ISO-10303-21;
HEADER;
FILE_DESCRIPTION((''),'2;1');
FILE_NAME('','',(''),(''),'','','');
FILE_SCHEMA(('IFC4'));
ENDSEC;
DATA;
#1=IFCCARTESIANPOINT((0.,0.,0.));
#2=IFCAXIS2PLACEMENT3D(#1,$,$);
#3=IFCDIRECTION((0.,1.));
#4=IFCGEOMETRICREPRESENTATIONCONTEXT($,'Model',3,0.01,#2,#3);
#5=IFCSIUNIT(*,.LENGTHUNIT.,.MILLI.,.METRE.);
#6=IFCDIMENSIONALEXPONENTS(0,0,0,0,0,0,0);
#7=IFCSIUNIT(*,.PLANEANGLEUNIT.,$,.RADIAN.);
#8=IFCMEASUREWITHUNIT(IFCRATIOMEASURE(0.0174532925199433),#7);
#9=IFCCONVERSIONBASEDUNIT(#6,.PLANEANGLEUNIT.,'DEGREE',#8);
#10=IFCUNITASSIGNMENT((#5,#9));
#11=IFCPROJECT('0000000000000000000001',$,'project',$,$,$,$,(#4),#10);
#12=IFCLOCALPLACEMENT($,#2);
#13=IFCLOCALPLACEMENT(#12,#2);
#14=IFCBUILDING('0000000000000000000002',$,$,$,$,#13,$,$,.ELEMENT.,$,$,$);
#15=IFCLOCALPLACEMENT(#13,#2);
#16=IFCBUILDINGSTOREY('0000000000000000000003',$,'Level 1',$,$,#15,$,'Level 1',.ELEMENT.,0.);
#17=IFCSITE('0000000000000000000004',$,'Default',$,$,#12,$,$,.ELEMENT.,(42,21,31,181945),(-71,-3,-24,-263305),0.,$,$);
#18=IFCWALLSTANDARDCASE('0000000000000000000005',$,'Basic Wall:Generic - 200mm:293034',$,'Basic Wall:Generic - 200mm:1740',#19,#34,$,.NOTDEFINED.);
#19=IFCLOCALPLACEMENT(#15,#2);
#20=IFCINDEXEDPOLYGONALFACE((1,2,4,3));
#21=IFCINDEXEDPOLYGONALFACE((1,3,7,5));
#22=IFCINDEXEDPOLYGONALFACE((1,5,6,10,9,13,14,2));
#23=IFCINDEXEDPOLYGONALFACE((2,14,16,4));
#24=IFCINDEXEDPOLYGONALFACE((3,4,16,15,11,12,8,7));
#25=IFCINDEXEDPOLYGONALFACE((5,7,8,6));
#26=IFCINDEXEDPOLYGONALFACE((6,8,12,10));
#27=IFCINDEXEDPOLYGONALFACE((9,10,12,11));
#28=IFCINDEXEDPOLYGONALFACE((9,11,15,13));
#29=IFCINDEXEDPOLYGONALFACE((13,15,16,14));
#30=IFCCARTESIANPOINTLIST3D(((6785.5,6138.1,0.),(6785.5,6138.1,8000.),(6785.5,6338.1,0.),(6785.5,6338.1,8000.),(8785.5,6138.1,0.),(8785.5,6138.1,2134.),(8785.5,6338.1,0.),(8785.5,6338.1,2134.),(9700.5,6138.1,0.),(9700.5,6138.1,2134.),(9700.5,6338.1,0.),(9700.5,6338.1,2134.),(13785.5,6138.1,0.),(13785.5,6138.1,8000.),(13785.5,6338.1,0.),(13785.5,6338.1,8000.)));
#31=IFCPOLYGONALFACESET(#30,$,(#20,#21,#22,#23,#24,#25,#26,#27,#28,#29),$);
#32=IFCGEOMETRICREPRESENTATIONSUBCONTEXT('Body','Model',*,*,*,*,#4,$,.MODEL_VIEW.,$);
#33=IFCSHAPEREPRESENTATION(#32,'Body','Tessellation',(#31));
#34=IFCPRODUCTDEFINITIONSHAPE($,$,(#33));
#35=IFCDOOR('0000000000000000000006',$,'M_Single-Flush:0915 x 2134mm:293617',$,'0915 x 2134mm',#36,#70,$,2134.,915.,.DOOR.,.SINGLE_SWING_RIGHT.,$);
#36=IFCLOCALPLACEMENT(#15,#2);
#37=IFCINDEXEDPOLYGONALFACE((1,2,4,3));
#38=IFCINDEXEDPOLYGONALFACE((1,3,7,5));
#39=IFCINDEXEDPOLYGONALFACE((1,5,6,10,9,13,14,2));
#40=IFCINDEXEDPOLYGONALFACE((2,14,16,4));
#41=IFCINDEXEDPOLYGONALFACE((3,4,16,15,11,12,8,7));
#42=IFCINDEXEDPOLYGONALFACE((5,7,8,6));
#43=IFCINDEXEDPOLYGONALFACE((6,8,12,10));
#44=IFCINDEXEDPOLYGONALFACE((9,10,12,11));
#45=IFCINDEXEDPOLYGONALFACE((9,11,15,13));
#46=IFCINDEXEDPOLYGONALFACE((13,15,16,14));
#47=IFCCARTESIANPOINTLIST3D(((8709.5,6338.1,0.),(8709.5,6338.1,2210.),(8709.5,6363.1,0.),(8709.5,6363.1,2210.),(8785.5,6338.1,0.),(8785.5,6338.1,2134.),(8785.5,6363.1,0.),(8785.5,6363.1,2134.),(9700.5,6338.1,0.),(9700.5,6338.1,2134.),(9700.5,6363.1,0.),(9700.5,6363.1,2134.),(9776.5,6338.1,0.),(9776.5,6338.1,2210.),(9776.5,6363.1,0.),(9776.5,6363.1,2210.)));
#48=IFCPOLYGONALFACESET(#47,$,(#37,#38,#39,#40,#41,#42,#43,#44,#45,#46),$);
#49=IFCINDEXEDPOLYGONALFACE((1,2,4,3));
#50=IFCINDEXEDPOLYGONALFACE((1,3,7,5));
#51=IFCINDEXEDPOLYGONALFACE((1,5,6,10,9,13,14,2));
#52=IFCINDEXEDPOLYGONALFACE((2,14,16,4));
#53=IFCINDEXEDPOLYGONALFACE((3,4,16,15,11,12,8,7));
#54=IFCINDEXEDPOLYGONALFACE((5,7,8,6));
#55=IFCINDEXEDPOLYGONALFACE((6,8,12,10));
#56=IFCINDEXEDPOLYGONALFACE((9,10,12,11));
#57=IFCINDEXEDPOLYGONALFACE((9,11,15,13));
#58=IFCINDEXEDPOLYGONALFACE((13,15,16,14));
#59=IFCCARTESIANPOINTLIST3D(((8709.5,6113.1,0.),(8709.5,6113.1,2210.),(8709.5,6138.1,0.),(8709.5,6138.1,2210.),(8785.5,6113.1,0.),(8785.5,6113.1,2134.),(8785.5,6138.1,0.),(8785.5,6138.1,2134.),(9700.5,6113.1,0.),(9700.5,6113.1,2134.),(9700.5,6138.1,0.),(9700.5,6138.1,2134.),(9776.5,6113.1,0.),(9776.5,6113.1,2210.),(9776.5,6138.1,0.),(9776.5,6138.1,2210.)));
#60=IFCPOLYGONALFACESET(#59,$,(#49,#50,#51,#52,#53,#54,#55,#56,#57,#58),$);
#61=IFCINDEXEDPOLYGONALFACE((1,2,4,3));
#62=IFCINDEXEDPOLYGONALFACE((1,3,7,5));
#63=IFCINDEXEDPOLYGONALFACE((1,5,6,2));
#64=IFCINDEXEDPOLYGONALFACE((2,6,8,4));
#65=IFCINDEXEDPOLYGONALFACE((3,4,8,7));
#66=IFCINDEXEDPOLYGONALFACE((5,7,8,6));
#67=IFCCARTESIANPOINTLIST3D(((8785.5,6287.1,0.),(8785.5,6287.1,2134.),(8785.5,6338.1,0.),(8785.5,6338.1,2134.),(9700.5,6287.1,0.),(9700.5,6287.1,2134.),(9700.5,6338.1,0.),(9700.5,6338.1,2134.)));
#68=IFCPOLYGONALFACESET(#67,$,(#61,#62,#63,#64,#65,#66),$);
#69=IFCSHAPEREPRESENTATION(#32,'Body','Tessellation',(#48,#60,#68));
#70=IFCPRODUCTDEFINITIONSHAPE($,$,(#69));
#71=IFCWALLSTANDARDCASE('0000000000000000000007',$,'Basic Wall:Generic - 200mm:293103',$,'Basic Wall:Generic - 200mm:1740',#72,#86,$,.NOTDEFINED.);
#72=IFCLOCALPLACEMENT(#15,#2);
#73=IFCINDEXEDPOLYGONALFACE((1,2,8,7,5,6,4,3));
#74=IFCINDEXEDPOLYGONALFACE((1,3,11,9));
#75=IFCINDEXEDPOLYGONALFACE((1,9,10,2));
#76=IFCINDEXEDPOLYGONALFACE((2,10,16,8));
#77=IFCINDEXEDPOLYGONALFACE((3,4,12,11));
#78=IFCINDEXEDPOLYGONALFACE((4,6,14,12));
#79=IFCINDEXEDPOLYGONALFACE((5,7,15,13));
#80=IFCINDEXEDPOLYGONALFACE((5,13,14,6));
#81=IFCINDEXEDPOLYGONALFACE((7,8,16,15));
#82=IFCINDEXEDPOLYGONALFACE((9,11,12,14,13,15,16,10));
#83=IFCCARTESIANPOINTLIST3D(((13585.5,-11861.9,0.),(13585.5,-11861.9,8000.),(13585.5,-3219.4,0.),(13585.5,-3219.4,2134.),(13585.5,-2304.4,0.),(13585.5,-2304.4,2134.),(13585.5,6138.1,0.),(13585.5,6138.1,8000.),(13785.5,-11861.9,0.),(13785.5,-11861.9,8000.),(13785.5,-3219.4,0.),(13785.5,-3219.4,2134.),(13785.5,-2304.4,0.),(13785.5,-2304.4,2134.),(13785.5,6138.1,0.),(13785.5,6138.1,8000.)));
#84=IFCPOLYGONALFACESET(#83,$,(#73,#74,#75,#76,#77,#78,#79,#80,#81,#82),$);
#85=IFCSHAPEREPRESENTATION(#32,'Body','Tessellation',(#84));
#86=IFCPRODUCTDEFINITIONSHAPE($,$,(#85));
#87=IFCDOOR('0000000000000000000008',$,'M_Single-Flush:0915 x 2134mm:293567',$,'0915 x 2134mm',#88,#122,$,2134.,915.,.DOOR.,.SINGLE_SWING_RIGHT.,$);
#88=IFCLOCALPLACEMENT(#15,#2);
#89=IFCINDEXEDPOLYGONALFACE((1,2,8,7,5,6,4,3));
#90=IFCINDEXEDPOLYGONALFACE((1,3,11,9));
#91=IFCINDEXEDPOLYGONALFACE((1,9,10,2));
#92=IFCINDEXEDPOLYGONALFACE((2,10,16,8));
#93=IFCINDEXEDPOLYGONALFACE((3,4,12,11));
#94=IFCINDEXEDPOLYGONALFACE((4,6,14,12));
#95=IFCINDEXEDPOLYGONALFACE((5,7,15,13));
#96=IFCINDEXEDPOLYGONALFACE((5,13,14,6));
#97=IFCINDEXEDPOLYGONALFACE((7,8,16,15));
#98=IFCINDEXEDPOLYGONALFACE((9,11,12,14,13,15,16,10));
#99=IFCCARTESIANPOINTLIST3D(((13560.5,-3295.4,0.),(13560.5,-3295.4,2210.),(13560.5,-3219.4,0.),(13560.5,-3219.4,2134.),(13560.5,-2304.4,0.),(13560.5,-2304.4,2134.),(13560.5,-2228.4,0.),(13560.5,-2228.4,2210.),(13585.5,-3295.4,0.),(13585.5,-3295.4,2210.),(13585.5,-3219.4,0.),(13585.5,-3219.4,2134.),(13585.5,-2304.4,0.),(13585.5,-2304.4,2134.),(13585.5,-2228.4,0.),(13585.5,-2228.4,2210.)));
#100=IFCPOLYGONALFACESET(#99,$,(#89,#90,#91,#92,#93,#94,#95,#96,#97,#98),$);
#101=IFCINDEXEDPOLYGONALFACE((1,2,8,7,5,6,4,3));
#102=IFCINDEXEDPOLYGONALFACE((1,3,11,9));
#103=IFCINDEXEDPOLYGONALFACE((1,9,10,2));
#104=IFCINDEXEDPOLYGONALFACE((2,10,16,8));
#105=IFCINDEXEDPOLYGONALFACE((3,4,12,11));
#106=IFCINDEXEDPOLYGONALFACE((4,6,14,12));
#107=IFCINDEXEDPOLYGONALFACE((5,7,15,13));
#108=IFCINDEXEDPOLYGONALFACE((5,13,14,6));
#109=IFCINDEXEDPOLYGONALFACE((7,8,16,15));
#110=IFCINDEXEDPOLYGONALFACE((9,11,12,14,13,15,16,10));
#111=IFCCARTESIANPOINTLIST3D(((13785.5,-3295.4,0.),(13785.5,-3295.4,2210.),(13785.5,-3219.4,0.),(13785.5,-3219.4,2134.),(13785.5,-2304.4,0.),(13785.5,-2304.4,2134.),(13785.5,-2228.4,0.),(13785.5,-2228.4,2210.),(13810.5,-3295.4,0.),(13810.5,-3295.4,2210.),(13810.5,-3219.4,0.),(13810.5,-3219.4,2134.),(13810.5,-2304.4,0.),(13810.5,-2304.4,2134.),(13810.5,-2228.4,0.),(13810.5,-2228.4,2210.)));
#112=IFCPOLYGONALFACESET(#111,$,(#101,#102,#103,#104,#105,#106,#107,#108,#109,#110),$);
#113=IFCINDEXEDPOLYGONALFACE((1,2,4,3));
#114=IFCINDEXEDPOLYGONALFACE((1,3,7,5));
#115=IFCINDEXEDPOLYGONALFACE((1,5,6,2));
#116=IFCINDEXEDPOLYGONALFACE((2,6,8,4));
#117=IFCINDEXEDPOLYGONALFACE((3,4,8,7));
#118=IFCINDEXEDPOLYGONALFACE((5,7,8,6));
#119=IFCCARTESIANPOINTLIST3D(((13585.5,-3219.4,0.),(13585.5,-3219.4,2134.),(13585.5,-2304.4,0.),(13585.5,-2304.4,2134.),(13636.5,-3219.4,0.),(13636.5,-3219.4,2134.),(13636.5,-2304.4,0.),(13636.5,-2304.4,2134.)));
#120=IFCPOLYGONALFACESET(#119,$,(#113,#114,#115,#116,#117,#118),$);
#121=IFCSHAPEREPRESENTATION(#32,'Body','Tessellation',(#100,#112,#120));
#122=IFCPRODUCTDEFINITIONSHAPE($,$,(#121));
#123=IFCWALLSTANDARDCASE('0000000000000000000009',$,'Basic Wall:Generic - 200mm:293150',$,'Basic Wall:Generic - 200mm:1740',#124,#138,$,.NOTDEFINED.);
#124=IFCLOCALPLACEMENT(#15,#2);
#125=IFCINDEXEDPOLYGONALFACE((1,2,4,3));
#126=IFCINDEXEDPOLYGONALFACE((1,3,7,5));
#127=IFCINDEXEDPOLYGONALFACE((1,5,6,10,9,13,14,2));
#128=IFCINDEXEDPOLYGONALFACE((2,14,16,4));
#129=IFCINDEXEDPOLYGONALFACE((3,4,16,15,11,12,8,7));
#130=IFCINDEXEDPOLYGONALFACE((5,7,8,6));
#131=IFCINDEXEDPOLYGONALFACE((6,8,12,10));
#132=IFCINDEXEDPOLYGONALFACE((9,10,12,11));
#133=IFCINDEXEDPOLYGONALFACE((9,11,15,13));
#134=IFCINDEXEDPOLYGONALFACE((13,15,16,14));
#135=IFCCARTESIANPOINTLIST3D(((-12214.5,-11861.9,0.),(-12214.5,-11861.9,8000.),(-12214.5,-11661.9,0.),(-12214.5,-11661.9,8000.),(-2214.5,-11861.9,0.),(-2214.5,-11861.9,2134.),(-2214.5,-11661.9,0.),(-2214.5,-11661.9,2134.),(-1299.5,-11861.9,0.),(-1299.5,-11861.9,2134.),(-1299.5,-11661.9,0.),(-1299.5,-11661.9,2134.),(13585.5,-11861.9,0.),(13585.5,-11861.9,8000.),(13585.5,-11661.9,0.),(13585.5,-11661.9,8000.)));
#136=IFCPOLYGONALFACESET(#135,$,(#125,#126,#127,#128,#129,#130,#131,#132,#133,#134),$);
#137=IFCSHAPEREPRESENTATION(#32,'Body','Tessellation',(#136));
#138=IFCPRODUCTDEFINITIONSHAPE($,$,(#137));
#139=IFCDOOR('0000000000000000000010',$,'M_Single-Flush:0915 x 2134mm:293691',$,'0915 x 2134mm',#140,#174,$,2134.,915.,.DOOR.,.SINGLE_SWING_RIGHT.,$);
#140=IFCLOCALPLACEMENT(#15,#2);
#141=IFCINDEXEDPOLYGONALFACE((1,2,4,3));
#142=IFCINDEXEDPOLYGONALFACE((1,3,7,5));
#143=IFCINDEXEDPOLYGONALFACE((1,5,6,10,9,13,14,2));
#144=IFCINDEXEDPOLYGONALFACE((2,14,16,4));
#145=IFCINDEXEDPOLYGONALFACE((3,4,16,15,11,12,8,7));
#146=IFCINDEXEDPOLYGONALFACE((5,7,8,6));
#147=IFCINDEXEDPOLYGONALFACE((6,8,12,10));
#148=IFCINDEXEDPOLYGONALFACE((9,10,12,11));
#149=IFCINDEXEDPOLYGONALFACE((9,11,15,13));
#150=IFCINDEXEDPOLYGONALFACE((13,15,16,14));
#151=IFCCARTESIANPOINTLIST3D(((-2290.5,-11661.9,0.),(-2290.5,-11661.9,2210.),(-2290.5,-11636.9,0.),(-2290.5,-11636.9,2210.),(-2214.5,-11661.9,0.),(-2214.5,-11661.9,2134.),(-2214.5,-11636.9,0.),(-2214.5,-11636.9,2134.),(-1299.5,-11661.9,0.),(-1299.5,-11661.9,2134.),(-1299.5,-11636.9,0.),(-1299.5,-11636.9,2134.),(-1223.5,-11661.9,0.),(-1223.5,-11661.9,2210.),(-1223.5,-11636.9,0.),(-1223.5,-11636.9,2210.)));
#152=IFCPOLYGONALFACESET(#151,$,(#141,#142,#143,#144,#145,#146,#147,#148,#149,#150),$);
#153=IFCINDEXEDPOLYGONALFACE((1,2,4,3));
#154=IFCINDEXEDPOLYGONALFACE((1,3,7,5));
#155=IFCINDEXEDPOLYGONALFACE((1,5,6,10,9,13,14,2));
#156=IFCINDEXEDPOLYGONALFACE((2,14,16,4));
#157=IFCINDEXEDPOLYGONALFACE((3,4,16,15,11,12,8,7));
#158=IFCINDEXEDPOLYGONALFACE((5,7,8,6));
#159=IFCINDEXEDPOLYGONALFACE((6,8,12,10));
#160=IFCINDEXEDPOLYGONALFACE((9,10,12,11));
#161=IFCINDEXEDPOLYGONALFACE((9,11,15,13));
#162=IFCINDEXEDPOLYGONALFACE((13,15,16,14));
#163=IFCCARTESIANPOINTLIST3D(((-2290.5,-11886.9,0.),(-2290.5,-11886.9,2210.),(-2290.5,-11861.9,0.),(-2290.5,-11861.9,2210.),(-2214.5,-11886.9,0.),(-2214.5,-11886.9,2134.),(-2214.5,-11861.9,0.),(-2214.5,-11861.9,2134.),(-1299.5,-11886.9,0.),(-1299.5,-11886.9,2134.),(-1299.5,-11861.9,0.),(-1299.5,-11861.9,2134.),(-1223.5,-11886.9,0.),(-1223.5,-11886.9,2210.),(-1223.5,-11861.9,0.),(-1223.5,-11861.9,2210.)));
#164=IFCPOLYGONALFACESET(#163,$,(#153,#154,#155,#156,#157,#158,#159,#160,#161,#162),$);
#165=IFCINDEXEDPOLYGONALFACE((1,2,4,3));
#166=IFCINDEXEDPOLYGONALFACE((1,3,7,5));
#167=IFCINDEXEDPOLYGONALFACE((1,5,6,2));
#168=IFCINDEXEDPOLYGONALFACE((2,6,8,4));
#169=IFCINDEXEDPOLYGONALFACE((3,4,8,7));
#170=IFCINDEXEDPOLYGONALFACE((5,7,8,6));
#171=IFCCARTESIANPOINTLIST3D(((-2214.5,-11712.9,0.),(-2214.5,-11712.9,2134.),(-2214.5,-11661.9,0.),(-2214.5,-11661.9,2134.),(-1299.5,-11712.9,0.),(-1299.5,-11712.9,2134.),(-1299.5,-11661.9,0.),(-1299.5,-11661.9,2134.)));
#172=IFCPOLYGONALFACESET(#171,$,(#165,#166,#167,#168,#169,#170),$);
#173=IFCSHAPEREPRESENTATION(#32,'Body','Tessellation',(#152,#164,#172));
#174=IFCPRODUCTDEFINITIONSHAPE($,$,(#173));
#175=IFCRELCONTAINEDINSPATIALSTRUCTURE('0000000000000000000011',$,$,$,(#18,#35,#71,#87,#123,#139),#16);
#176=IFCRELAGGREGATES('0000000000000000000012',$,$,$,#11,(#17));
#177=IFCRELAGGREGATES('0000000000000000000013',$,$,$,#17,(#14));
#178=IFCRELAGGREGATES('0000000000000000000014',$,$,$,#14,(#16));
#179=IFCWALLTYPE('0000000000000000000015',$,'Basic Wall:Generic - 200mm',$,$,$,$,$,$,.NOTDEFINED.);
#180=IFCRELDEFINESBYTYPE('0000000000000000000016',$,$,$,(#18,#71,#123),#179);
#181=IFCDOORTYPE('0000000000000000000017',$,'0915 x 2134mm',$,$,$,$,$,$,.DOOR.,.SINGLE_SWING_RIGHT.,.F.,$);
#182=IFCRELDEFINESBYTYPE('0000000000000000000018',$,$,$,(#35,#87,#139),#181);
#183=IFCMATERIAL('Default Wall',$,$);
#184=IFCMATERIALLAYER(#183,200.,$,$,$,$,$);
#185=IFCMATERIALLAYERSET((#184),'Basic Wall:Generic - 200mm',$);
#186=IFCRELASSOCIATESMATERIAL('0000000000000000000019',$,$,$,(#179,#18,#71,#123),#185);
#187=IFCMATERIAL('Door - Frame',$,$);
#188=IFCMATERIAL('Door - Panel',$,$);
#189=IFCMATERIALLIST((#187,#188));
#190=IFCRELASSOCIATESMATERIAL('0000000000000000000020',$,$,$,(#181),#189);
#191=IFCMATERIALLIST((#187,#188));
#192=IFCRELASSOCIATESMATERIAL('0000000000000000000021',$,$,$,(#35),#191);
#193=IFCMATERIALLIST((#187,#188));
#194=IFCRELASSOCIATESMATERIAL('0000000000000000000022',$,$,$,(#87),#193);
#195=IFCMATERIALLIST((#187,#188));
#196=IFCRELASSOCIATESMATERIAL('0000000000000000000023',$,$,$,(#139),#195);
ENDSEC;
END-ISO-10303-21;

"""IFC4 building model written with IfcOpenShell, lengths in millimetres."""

from ifc_helpers import new_model, entity, si_unit, converted_unit, direction, frame, frame_2d, origin, place, context, subcontext, project, spatial, polyline, rectangle, outline, extrude, source, transform, mapped, material, material_list, layer, layer_set, layer_usage, type_object, type_shapes, element, fill, save


model = new_model("IFC4")

# Units and contexts
model_context = context("Model", 3, precision=0.01, world=origin(), true_north=direction((0.0, 1.0)))
body_context = subcontext(model_context, "Body", "Model", "MODEL_VIEW")
ifc_project = project(units=[si_unit("LENGTHUNIT", "METRE", prefix="MILLI"), converted_unit("PLANEANGLEUNIT", "DEGREE", entity("IfcRatioMeasure", 0.0174532925199433), si_unit("PLANEANGLEUNIT", "RADIAN"), dimensions=[0, 0, 0, 0, 0, 0, 0])], contexts=[model_context])

# Site, building, storey
site_placement = place(None, origin())
site = spatial("IfcSite", under=ifc_project, at=site_placement, Name="Default", CompositionType="ELEMENT", RefLatitude=(42, 21, 31, 181945), RefLongitude=(-71, -3, -24, -263305), RefElevation=0.0)
building_placement = place(site_placement, origin())
building = spatial("IfcBuilding", under=site, at=building_placement, CompositionType="ELEMENT")
storey_placement = place(building_placement, origin())
storey = spatial("IfcBuildingStorey", under=building, at=storey_placement, Name="Level 1", LongName="Level 1", CompositionType="ELEMENT", Elevation=0.0)

# Shared definitions
ifc_material_1 = material(Name="Default Wall")
ifc_layer_1 = layer(ifc_material_1, 200.0)
ifc_layer_set_1 = layer_set([ifc_layer_1], Name="Basic Wall:Generic - 200mm")
wall_type = type_object("IfcWallType", Name="Basic Wall:Generic - 200mm", PredefinedType="NOTDEFINED", material=ifc_layer_set_1)
ifc_material_2 = material(Name="Door - Frame")
ifc_material_3 = material(Name="Door - Panel")
ifc_material_list_1 = material_list([ifc_material_2, ifc_material_3])
door_type = type_object("IfcDoorType", Name="0915 x 2134mm", OperationType="SINGLE_SWING_RIGHT", ParameterTakesPrecedence=False, PredefinedType="DOOR", material=ifc_material_list_1)
shared_shape = source(origin(), body_context, "Body", "SweptSolid", [
    extrude(outline(polyline([(-533.5, -1124.0), (533.5, -1124.0), (533.5, 1086.0), (457.5, 1086.0), (457.5, -1048.0), (-457.5, -1048.0), (-457.5, 1086.0), (-533.5, 1086.0), (-533.5, -1124.0)])), frame((457.5, 200.0, 1086.0), z_axis=(0.0, 1.0, 0.0), x_axis=(1.0, 0.0, 0.0)), (0.0, 0.0, 1.0), 25.0),
    extrude(outline(polyline([(-1124.0, -533.5), (1086.0, -533.5), (1086.0, -457.5), (-1048.0, -457.5), (-1048.0, 457.5), (1086.0, 457.5), (1086.0, 533.5), (-1124.0, 533.5), (-1124.0, -533.5)])), frame((457.5, -25.0, 1086.0), z_axis=(0.0, 1.0, 0.0), x_axis=(0.0, 0.0, -1.0)), (0.0, 0.0, 1.0), 25.0),
    extrude(rectangle(XDim=51.0, YDim=915.0, at=frame_2d((0.0, 0.0), x_axis=(1.0, 0.0))), frame((457.5, 174.5, 0.0), z_axis=(0.0, 0.0, 1.0), x_axis=(0.0, 1.0, 0.0)), (0.0, 0.0, 1.0), 2134.0),
])
type_shapes(door_type, [shared_shape])

# Walls, openings, doors
ifc_layer_usage_1 = layer_usage(ifc_layer_set_1, "AXIS2", "NEGATIVE", 100.0)
wall_1_placement = place(storey_placement, frame((6785.5, 6238.1, 0.0)))
wall_1 = element("IfcWallStandardCase", 1, at=wall_1_placement, inside=storey, type_object=wall_type, material=ifc_layer_usage_1, Name="Basic Wall:Generic - 200mm:293034", ObjectType="Basic Wall:Generic - 200mm:1740", PredefinedType="NOTDEFINED", context=body_context, shape_type="SweptSolid", body=[
    extrude(rectangle(XDim=7000.0, YDim=200.0, at=frame_2d((3500.0, 0.0), x_axis=(-1.0, 0.0))), origin(), (0.0, 0.0, 1.0), 8000.0),
])
opening_1_placement = place(wall_1_placement, frame((2000.0, -100.0, 0.0)))
opening_1 = element("IfcOpeningElement", 2, at=opening_1_placement, cuts=wall_1, ObjectType="Opening", PredefinedType="OPENING", context=body_context, shape_type="SweptSolid", body=[
    extrude(rectangle(XDim=915.0, YDim=2134.0, at=frame_2d((1067.0, 457.5), x_axis=(0.0, 1.0))), frame((0.0, 0.0, 0.0), z_axis=(0.0, 1.0, 0.0), x_axis=(0.0, 0.0, 1.0)), (0.0, 0.0, 1.0), 200.0),
])
ifc_material_list_2 = material_list([ifc_material_2, ifc_material_3])
door_1_placement = place(opening_1_placement, origin())
door_1 = element("IfcDoor", 3, at=door_1_placement, inside=storey, type_object=door_type, material=ifc_material_list_2, Name="M_Single-Flush:0915 x 2134mm:293617", ObjectType="0915 x 2134mm", OperationType="SINGLE_SWING_RIGHT", OverallHeight=2134.0, OverallWidth=915.0, PredefinedType="DOOR", context=body_context, shape_type="MappedRepresentation", body=[
    mapped(shared_shape, transform((0.0, 0.0, 0.0), scale=1.0)),
])
fill(opening_1, door_1)
ifc_layer_usage_2 = layer_usage(ifc_layer_set_1, "AXIS2", "NEGATIVE", 100.0)
wall_2_placement = place(storey_placement, frame((13685.5, 6138.1, 0.0), z_axis=(0.0, 0.0, 1.0), x_axis=(0.0, -1.0, 0.0)))
wall_2 = element("IfcWallStandardCase", 4, at=wall_2_placement, inside=storey, type_object=wall_type, material=ifc_layer_usage_2, Name="Basic Wall:Generic - 200mm:293103", ObjectType="Basic Wall:Generic - 200mm:1740", PredefinedType="NOTDEFINED", context=body_context, shape_type="SweptSolid", body=[
    extrude(rectangle(XDim=18000.0, YDim=200.0, at=frame_2d((9000.0, 0.0), x_axis=(-1.0, 0.0))), origin(), (0.0, 0.0, 1.0), 8000.0),
])
opening_2_placement = place(wall_2_placement, frame((9357.5, 100.0, 0.0)))
opening_2 = element("IfcOpeningElement", 5, at=opening_2_placement, cuts=wall_2, ObjectType="Opening", PredefinedType="OPENING", context=body_context, shape_type="SweptSolid", body=[
    extrude(rectangle(XDim=915.0, YDim=2134.0, at=frame_2d((1067.0, 457.5), x_axis=(0.0, 1.0))), frame((0.0, 0.0, 0.0), z_axis=(0.0, -1.0, 0.0), x_axis=(0.0, 0.0, 1.0)), (0.0, 0.0, 1.0), 200.0),
])
ifc_material_list_3 = material_list([ifc_material_2, ifc_material_3])
door_2_placement = place(opening_2_placement, frame((0.0, 0.0, 0.0), z_axis=(0.0, 0.0, 1.0), x_axis=(-1.0, 0.0, 0.0)))
door_2 = element("IfcDoor", 6, at=door_2_placement, inside=storey, type_object=door_type, material=ifc_material_list_3, Name="M_Single-Flush:0915 x 2134mm:293567", ObjectType="0915 x 2134mm", OperationType="SINGLE_SWING_RIGHT", OverallHeight=2134.0, OverallWidth=915.0, PredefinedType="DOOR", context=body_context, shape_type="MappedRepresentation", body=[
    mapped(shared_shape, transform((0.0, 0.0, 0.0), scale=1.0)),
])
fill(opening_2, door_2)
ifc_layer_usage_3 = layer_usage(ifc_layer_set_1, "AXIS2", "NEGATIVE", 100.0)
wall_3_placement = place(storey_placement, frame((13585.5, -11761.9, 0.0), z_axis=(0.0, 0.0, 1.0), x_axis=(-1.0, 0.0, 0.0)))
wall_3 = element("IfcWallStandardCase", 7, at=wall_3_placement, inside=storey, type_object=wall_type, material=ifc_layer_usage_3, Name="Basic Wall:Generic - 200mm:293150", ObjectType="Basic Wall:Generic - 200mm:1740", PredefinedType="NOTDEFINED", context=body_context, shape_type="SweptSolid", body=[
    extrude(rectangle(XDim=25800.0, YDim=200.0, at=frame_2d((12900.0, 0.0), x_axis=(-1.0, 0.0))), origin(), (0.0, 0.0, 1.0), 8000.0),
])
opening_3_placement = place(wall_3_placement, frame((15800.0, 100.0, 0.0)))
opening_3 = element("IfcOpeningElement", 8, at=opening_3_placement, cuts=wall_3, ObjectType="Opening", PredefinedType="OPENING", context=body_context, shape_type="SweptSolid", body=[
    extrude(rectangle(XDim=915.0, YDim=2134.0, at=frame_2d((1067.0, 457.5), x_axis=(0.0, 1.0))), frame((0.0, 0.0, 0.0), z_axis=(0.0, -1.0, 0.0), x_axis=(0.0, 0.0, 1.0)), (0.0, 0.0, 1.0), 200.0),
])
ifc_material_list_4 = material_list([ifc_material_2, ifc_material_3])
door_3_placement = place(opening_3_placement, frame((0.0, 0.0, 0.0), z_axis=(0.0, 0.0, 1.0), x_axis=(-1.0, 0.0, 0.0)))
door_3 = element("IfcDoor", 9, at=door_3_placement, inside=storey, type_object=door_type, material=ifc_material_list_4, Name="M_Single-Flush:0915 x 2134mm:293691", ObjectType="0915 x 2134mm", OperationType="SINGLE_SWING_RIGHT", OverallHeight=2134.0, OverallWidth=915.0, PredefinedType="DOOR", context=body_context, shape_type="MappedRepresentation", body=[
    mapped(shared_shape, transform((0.0, 0.0, 0.0), scale=1.0)),
])
fill(opening_3, door_3)

save(model, "model.ifc")
